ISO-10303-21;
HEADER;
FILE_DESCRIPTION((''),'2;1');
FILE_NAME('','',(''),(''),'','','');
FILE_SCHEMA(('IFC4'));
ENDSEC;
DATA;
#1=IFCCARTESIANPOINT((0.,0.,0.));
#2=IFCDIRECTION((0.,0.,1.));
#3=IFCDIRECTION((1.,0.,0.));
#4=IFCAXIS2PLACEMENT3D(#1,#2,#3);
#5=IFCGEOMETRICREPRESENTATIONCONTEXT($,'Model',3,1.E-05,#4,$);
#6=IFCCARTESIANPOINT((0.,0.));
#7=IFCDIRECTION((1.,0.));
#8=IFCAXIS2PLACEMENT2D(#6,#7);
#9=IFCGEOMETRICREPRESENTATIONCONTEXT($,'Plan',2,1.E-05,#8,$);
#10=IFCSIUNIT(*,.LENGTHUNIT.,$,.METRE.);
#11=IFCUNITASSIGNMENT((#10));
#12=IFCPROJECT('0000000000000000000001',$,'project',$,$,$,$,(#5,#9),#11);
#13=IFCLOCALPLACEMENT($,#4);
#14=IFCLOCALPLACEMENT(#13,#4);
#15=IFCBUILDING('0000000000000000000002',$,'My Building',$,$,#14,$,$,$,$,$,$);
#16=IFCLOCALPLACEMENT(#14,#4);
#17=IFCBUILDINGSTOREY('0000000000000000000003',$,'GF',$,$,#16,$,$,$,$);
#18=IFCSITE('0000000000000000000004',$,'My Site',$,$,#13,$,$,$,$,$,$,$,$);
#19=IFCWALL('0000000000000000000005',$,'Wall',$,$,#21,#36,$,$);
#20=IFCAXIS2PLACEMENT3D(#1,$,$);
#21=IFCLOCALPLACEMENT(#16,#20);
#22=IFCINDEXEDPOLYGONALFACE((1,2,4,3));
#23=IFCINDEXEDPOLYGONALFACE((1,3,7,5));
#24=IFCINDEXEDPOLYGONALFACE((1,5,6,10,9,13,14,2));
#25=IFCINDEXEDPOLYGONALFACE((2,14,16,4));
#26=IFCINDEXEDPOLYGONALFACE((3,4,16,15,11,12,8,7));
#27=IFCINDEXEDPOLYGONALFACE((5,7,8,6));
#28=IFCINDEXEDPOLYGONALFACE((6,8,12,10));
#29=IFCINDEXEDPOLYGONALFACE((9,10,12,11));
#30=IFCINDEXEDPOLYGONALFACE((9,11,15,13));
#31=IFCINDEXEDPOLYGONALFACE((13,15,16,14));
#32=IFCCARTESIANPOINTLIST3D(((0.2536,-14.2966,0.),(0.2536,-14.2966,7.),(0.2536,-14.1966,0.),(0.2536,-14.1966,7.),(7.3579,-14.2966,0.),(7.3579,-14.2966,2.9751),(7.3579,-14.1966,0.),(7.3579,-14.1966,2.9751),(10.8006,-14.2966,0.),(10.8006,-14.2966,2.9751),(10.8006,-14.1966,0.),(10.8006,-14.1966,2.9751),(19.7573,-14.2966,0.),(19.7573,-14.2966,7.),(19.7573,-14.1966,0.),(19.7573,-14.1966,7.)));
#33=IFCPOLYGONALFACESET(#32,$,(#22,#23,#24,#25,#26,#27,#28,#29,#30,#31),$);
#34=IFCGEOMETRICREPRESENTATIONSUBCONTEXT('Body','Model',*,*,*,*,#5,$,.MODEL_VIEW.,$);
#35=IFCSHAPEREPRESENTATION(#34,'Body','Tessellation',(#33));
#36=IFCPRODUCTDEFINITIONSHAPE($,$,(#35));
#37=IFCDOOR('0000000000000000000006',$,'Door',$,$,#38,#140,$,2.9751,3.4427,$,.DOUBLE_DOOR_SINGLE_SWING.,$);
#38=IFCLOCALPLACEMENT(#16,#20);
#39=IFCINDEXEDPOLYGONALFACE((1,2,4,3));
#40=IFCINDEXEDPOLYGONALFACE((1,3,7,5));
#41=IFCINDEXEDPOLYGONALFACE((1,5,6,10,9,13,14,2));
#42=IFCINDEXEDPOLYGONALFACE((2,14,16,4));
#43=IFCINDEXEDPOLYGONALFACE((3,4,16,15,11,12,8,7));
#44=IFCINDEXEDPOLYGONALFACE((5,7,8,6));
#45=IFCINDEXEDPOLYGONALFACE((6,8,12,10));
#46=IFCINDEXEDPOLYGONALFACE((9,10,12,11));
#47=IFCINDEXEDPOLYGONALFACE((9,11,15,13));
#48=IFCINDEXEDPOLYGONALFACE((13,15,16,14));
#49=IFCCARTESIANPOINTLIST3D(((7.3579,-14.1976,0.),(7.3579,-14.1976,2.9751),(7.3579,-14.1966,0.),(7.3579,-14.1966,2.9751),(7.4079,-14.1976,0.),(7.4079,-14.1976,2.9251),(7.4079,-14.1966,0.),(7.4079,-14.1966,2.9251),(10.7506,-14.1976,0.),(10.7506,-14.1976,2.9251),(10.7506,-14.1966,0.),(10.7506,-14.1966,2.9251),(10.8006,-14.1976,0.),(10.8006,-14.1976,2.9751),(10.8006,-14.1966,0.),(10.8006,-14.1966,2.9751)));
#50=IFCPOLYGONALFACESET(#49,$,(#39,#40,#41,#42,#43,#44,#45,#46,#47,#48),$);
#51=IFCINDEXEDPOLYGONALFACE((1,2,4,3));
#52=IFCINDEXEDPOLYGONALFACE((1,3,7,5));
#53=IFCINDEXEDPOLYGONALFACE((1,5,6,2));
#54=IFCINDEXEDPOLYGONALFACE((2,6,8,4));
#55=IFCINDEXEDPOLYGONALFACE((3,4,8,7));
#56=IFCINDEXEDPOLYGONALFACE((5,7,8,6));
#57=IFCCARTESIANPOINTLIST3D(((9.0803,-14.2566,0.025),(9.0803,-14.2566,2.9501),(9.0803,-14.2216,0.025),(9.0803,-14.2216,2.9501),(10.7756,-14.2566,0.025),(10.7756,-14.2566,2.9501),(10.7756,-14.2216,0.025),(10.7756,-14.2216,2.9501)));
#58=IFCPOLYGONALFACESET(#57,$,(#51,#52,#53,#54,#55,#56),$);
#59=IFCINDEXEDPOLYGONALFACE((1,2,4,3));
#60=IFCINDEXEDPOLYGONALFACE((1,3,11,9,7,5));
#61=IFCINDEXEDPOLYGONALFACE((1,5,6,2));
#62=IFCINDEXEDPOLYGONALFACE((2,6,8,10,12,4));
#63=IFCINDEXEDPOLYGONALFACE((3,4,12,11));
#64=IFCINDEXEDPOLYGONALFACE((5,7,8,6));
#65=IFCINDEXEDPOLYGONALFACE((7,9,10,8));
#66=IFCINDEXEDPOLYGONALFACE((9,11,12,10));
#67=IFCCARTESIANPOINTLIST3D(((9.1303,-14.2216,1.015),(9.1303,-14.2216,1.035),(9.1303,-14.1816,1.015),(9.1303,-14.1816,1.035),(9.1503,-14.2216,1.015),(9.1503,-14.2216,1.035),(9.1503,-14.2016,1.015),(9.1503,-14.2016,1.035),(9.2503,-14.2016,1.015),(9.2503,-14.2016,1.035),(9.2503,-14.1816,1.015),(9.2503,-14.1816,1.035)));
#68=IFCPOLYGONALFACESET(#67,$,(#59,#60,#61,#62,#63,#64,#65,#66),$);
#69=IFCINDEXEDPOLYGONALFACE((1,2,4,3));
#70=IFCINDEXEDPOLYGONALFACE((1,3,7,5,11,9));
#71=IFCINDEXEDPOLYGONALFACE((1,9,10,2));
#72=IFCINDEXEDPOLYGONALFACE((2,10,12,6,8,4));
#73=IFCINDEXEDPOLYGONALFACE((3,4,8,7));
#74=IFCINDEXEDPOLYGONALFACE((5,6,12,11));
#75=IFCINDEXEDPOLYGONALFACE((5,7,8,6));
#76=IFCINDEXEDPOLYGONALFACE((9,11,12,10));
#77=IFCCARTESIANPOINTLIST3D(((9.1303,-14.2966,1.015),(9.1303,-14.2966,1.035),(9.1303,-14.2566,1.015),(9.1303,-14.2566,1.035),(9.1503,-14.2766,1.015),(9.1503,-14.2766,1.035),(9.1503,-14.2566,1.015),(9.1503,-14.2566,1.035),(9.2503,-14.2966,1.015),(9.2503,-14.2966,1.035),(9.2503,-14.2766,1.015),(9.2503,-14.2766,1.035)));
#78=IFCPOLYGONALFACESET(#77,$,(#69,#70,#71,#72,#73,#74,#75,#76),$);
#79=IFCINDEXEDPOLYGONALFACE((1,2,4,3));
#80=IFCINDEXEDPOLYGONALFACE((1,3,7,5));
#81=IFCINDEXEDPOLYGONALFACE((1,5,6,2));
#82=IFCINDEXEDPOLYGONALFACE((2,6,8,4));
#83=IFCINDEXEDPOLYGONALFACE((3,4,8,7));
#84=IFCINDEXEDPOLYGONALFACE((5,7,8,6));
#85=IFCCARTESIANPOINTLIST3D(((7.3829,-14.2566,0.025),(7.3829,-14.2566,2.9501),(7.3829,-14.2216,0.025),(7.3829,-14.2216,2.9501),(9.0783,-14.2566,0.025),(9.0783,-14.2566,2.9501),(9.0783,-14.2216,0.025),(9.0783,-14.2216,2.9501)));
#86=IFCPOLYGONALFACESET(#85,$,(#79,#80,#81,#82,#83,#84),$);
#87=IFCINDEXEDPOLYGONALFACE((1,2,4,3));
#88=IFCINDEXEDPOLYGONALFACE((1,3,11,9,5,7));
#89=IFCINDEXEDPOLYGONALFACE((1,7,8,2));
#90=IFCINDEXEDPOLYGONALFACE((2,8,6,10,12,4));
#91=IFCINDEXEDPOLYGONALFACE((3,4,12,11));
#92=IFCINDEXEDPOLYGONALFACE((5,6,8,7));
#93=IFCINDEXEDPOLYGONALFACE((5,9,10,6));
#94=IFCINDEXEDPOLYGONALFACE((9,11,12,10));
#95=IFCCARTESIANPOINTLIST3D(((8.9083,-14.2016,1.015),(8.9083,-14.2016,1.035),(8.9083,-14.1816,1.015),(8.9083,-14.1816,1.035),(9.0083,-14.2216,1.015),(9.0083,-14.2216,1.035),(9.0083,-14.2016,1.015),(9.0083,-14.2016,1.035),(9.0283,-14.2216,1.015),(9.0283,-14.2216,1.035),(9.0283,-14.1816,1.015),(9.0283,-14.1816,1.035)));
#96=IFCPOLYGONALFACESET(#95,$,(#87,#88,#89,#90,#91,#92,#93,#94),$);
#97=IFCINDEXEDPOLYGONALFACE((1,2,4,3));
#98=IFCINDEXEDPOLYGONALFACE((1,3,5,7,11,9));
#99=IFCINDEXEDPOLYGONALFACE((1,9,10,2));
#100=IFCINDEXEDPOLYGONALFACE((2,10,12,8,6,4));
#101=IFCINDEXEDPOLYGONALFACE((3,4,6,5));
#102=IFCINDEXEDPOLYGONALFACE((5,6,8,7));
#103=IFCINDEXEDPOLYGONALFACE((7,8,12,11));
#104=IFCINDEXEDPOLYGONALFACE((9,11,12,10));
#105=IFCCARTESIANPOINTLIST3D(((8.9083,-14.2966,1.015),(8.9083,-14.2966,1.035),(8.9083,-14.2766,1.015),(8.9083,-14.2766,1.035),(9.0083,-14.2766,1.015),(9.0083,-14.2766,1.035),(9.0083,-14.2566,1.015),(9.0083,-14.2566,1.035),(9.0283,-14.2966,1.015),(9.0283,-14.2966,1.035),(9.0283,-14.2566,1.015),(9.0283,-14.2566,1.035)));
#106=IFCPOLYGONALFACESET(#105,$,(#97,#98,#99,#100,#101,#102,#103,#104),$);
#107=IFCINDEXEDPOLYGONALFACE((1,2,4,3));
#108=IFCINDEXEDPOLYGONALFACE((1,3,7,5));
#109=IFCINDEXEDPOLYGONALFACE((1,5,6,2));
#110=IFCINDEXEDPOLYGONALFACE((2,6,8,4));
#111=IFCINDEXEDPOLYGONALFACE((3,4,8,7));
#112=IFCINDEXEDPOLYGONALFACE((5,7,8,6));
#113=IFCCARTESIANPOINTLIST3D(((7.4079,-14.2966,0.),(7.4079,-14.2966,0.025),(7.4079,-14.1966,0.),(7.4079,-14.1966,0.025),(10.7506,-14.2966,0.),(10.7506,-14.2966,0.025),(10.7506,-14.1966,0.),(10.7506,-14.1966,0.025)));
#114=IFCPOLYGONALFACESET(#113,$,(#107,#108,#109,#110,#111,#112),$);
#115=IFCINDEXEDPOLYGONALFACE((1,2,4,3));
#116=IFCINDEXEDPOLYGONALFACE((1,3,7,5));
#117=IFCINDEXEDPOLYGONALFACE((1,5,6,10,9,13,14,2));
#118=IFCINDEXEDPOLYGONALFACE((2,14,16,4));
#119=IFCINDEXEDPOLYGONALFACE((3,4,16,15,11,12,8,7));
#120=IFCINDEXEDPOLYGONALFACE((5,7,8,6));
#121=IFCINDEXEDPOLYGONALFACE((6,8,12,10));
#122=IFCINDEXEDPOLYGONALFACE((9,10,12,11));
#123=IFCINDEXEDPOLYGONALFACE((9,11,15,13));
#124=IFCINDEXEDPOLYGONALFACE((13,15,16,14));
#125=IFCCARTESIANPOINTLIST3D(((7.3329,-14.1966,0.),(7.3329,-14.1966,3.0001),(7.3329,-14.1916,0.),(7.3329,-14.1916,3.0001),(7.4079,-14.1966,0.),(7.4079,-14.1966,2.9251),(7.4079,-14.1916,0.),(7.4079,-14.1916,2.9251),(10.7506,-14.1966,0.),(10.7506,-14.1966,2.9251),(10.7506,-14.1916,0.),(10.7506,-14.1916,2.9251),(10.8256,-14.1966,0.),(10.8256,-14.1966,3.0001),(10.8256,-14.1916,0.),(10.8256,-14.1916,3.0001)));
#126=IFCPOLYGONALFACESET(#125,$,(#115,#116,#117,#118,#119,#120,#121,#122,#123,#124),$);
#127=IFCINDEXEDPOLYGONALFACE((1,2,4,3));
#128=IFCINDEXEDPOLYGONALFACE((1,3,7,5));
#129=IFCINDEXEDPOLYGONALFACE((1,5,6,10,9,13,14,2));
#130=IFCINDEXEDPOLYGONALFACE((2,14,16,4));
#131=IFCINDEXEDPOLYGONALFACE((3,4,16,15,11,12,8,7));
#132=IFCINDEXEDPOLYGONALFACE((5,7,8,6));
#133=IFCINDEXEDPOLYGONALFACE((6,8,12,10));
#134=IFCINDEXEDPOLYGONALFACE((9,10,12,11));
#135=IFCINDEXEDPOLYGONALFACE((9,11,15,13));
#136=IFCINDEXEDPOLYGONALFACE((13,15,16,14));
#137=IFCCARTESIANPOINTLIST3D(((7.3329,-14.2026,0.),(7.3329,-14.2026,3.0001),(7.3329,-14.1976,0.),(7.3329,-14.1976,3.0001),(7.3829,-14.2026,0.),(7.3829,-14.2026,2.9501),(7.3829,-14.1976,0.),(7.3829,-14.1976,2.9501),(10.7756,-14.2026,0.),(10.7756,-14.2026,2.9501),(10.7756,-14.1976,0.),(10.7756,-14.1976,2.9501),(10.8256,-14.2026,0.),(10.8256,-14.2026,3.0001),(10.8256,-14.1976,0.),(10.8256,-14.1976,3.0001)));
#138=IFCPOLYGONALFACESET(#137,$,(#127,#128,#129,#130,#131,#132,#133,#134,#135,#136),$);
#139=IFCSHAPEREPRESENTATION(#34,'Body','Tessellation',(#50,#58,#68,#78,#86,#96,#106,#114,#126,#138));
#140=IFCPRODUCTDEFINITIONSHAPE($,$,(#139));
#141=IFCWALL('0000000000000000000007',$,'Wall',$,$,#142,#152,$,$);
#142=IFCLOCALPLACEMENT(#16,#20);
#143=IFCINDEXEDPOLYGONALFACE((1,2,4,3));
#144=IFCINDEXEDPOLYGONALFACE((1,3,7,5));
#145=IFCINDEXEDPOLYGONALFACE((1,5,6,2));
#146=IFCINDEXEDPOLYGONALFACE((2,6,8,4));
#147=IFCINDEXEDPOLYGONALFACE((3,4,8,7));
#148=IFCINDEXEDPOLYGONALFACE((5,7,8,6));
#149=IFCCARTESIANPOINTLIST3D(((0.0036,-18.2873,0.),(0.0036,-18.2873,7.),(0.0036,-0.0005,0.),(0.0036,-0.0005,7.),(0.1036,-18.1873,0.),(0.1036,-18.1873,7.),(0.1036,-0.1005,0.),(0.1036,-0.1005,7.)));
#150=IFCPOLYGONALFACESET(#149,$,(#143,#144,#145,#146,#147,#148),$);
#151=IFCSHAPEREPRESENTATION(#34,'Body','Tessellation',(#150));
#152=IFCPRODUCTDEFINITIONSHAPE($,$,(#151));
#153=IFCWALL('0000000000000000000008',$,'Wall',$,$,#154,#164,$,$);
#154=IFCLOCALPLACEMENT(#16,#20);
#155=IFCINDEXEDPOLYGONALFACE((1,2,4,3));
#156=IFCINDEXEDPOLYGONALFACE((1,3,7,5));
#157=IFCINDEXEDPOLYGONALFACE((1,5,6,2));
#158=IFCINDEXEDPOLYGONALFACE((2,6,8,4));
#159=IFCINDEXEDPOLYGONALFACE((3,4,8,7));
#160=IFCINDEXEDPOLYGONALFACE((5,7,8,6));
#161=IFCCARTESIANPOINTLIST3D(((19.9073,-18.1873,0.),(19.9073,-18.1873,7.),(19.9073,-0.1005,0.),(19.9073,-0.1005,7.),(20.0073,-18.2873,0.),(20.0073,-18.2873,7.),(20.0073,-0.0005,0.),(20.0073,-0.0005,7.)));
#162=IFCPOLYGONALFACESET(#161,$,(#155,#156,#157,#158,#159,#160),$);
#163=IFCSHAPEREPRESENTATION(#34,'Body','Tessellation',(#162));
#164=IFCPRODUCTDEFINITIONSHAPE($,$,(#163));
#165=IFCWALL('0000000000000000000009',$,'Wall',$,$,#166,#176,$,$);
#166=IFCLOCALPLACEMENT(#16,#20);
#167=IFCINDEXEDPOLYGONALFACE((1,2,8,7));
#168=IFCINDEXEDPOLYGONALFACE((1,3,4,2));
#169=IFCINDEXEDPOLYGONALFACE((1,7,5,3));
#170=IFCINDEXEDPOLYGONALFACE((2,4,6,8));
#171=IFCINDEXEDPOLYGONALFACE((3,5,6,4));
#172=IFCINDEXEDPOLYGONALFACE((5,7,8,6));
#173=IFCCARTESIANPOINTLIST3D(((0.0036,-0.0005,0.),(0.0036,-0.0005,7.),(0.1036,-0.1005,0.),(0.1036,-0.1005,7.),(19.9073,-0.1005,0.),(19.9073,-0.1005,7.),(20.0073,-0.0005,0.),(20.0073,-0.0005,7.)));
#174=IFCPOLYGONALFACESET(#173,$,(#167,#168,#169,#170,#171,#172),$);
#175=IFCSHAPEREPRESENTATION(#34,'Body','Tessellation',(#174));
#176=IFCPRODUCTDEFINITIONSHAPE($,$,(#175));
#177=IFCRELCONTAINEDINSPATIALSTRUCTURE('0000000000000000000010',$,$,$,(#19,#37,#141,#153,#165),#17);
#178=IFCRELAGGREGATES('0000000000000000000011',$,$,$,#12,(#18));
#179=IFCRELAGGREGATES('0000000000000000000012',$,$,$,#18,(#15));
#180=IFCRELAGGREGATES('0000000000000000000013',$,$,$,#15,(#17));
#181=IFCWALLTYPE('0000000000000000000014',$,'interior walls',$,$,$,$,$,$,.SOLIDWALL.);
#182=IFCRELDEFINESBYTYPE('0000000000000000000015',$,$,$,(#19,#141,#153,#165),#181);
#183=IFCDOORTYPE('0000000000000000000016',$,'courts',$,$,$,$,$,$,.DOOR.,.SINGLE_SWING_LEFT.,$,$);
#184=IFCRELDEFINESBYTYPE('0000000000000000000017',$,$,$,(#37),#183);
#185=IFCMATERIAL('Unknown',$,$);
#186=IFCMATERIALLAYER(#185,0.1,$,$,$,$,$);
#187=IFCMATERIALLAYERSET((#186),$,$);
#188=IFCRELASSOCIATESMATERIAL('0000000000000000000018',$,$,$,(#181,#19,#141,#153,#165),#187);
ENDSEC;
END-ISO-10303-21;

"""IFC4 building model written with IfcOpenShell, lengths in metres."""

from ifc_helpers import new_model, entity, si_unit, frame, origin_with_axes, origin_2d_with_axis, place, context, subcontext, project, spatial, line, indexed_curve, outline, extrude, shape, source, transform, mapped, material, layer, layer_set, layer_usage, type_object, type_shapes, element, fill, save


model = new_model("IFC4")

# Units and contexts
model_context = context("Model", 3, precision=1e-05, world=origin_with_axes())
plan_context = context("Plan", 2, precision=1e-05, world=origin_2d_with_axis())
body_context_1 = subcontext(model_context, "Body", "Model", "MODEL_VIEW")
body_context_2 = subcontext(plan_context, "Body", "Plan", "PLAN_VIEW")
ifc_project = project(units=[si_unit("LENGTHUNIT", "METRE")], contexts=[model_context, plan_context])

# Site, building, storey
site_placement = place(None, origin_with_axes())
site = spatial("IfcSite", under=ifc_project, at=site_placement, Name="My Site")
building_placement = place(site_placement, origin_with_axes())
building = spatial("IfcBuilding", under=site, at=building_placement, Name="My Building")
storey_placement = place(building_placement, origin_with_axes())
storey = spatial("IfcBuildingStorey", under=building, at=storey_placement, Name="GF")

# Shared definitions
ifc_material = material(Name="Unknown")

# Wall, opening, door
ifc_layer_1 = layer(ifc_material, 0.1)
ifc_layer_set_1 = layer_set([ifc_layer_1])
ifc_layer_usage_1 = layer_usage(ifc_layer_set_1, "AXIS2", "POSITIVE", 0.0)
wall_type = type_object("IfcWallType", Name="interior walls", PredefinedType="SOLIDWALL", material=ifc_layer_set_1)
wall_1_placement = place(storey_placement, frame((0.2536, -14.2966, 0.0), z_axis=(0.0, 0.0, 1.0), x_axis=(1.0, 0.0, 0.0)))
wall_1 = element("IfcWall", 1, at=wall_1_placement, inside=storey, type_object=wall_type, material=ifc_layer_usage_1, Name="Wall", context=body_context_1, shape_type="SweptSolid", body=[
    extrude(outline(indexed_curve([(0.0, 0.0), (0.0, 0.1), (19.5037, 0.1), (19.5037, 0.0)], segments=[line(1, 2, 3, 4, 1)])), origin_with_axes(), (0.0, 0.0, 1.0), 7.0),
])
shared_shape_1 = source(origin_with_axes(), body_context_1, "Body", "SweptSolid", [
    extrude(outline(indexed_curve([(0.0, 0.0), (3.4427, 0.0), (3.4427, 2.9751), (0.0, 2.9751)], segments=[line(1, 2, 3, 4, 1)])), frame((0.0, -0.6, 0.0), z_axis=(0.0, -1.0, 0.0), x_axis=(1.0, 0.0, 0.0)), (0.0, 0.0, -1.0), 1.2),
])
opening_1_placement = place(wall_1_placement, frame((10.547, 0.1, 0.0), z_axis=(0.0, 0.0, 1.0), x_axis=(-1.0, 0.0, 0.0)))
opening_1 = element("IfcOpeningElement", 2, at=opening_1_placement, cuts=wall_1, PredefinedType="OPENING", context=body_context_1, shape_type="MappedRepresentation", body=[
    mapped(shared_shape_1, transform((0.0, 0.0, 0.0), x_axis=(1.0, 0.0, 0.0), y_axis=(0.0, 1.0, 0.0), z_axis=(0.0, 0.0, 1.0), scale=1.0)),
])
door_type_1 = type_object("IfcDoorType", Name="courts", OperationType="SINGLE_SWING_LEFT", PredefinedType="DOOR")
shared_shape_2 = source(origin_with_axes(), body_context_1, "Body", "SweptSolid", [
    extrude(outline(indexed_curve([(0.0, 0.0), (0.0, 2.9751), (3.4427, 2.9751), (3.4427, 0.0), (3.3927, 0.0), (3.3927, 2.9251), (0.05, 2.9251), (0.05, 0.0)], segments=[line(1, 2, 3, 4, 5, 6, 7, 8, 1)])), frame((0.0, 0.0, 0.0), z_axis=(0.0, -1.0, 0.0), x_axis=(1.0, 0.0, 0.0)), (0.0, 0.0, -1.0), 0.001),
    extrude(outline(indexed_curve([(0.0, 0.0), (1.6954, 0.0), (1.6954, 0.035), (0.0, 0.035)], segments=[line(1, 2, 3, 4, 1)])), frame((0.025, 0.025, 0.025), z_axis=(0.0, 0.0, 1.0), x_axis=(1.0, 0.0, 0.0)), (0.0, 0.0, 1.0), 2.9251),
    extrude(outline(indexed_curve([(0.0, 0.0), (0.0, -0.04), (-0.12, -0.04), (-0.12, -0.02), (-0.02, -0.02), (-0.02, 0.0)], segments=[line(1, 2, 3, 4, 5, 6, 1)])), frame((1.6704, 0.025, 1.015), z_axis=(0.0, 0.0, 1.0), x_axis=(1.0, 0.0, 0.0)), (0.0, 0.0, 1.0), 0.02),
    extrude(outline(indexed_curve([(0.0, 0.0), (0.0, 0.04), (-0.12, 0.04), (-0.12, 0.02), (-0.02, 0.02), (-0.02, 0.0)], segments=[line(1, 2, 3, 4, 5, 6, 1)])), frame((1.6704, 0.06, 1.015), z_axis=(0.0, 0.0, 1.0), x_axis=(1.0, 0.0, 0.0)), (0.0, 0.0, 1.0), 0.02),
    extrude(outline(indexed_curve([(0.0, 0.0), (-1.6954, 0.0), (-1.6954, 0.035), (0.0, 0.035)], segments=[line(1, 2, 3, 4, 1)])), frame((3.4177, 0.025, 0.025), z_axis=(0.0, 0.0, 1.0), x_axis=(1.0, 0.0, 0.0)), (0.0, 0.0, 1.0), 2.9251),
    extrude(outline(indexed_curve([(0.0, 0.0), (0.0, -0.04), (0.12, -0.04), (0.12, -0.02), (0.02, -0.02), (0.02, 0.0)], segments=[line(1, 2, 3, 4, 5, 6, 1)])), frame((1.7724, 0.025, 1.015), z_axis=(0.0, 0.0, 1.0), x_axis=(1.0, 0.0, 0.0)), (0.0, 0.0, 1.0), 0.02),
    extrude(outline(indexed_curve([(0.0, 0.0), (0.0, 0.04), (0.12, 0.04), (0.12, 0.02), (0.02, 0.02), (0.02, 0.0)], segments=[line(1, 2, 3, 4, 5, 6, 1)])), frame((1.7724, 0.06, 1.015), z_axis=(0.0, 0.0, 1.0), x_axis=(1.0, 0.0, 0.0)), (0.0, 0.0, 1.0), 0.02),
    extrude(outline(indexed_curve([(0.0, 0.0), (3.3427, 0.0), (3.3427, 0.1), (0.0, 0.1)], segments=[line(1, 2, 3, 4, 1)])), frame((0.05, 0.0, 0.0), z_axis=(0.0, 0.0, 1.0), x_axis=(1.0, 0.0, 0.0)), (0.0, 0.0, 1.0), 0.025),
    extrude(outline(indexed_curve([(0.0, 0.0), (0.0, 3.0001), (3.4927, 3.0001), (3.4927, 0.0), (3.4177, 0.0), (3.4177, 2.9251), (0.075, 2.9251), (0.075, 0.0)], segments=[line(1, 2, 3, 4, 5, 6, 7, 8, 1)])), frame((-0.025, -0.005, 0.0), z_axis=(0.0, -1.0, 0.0), x_axis=(1.0, 0.0, 0.0)), (0.0, 0.0, -1.0), 0.005),
    extrude(outline(indexed_curve([(0.0, 0.0), (0.0, 3.0001), (3.4927, 3.0001), (3.4927, 0.0), (3.4427, 0.0), (3.4427, 2.9501), (0.05, 2.9501), (0.05, 0.0)], segments=[line(1, 2, 3, 4, 5, 6, 7, 8, 1)])), frame((-0.025, 0.001, 0.0), z_axis=(0.0, -1.0, 0.0), x_axis=(1.0, 0.0, 0.0)), (0.0, 0.0, -1.0), 0.005),
])
shared_shape_3 = source(origin_with_axes(), body_context_2, "Body", "Curve2D", [
    entity("IfcIndexedPolyCurve", entity("IfcCartesianPointList2D", [[0.0, 0.0], [0.05, 0.0], [0.05, 0.001], [0.0, 0.001]]), [entity("IfcLineIndex", [1, 2, 3, 4, 1])]),
    entity("IfcIndexedPolyCurve", entity("IfcCartesianPointList2D", [[3.4427, 0.0], [3.3927, 0.0], [3.3927, 0.001], [3.4427, 0.001]]), [entity("IfcLineIndex", [1, 2, 3, 4, 1])]),
    entity("IfcTrimmedCurve", entity("IfcEllipse", entity("IfcAxis2Placement2D", entity("IfcCartesianPoint", [0.06, 0.001]), entity("IfcDirection", [1.0, 0.0])), 1.6614, 1.6964), [entity("IfcCartesianPoint", [1.7214, 0.001])], [entity("IfcCartesianPoint", [0.06, 1.6974])], True, "CARTESIAN"),
    entity("IfcIndexedPolyCurve", entity("IfcCartesianPointList2D", [[0.025, 0.001], [0.06, 0.001], [0.06, 1.6974], [0.025, 1.6974]]), [entity("IfcLineIndex", [1, 2, 3, 4, 1])]),
    entity("IfcTrimmedCurve", entity("IfcEllipse", entity("IfcAxis2Placement2D", entity("IfcCartesianPoint", [3.3827, 0.001]), entity("IfcDirection", [1.0, 0.0])), 1.6614, 1.6964), [entity("IfcCartesianPoint", [3.3827, 1.6974])], [entity("IfcCartesianPoint", [1.7214, 0.001])], True, "CARTESIAN"),
    entity("IfcIndexedPolyCurve", entity("IfcCartesianPointList2D", [[3.4177, 0.001], [3.3827, 0.001], [3.3827, 1.6974], [3.4177, 1.6974]]), [entity("IfcLineIndex", [1, 2, 3, 4, 1])]),
])
type_shapes(door_type_1, [shared_shape_2, shared_shape_3])
door_1_placement = place(opening_1_placement, origin_with_axes())
door_1 = element("IfcDoor", 3, at=door_1_placement, inside=storey, type_object=door_type_1, Name="Door", OperationType="DOUBLE_DOOR_SINGLE_SWING", OverallHeight=2.9751, OverallWidth=3.4427, shapes=[
    shape(body_context_1, "Body", "MappedRepresentation", [mapped(shared_shape_2, transform((0.0, 0.0, 0.0), x_axis=(1.0, 0.0, 0.0), y_axis=(0.0, 1.0, 0.0), z_axis=(0.0, 0.0, 1.0), scale=1.0))]),
    shape(body_context_2, "Body", "MappedRepresentation", [mapped(shared_shape_3, transform((0.0, 0.0, 0.0), x_axis=(1.0, 0.0, 0.0), y_axis=(0.0, 1.0, 0.0), z_axis=(0.0, 0.0, 1.0), scale=1.0))]),
])
fill(opening_1, door_1)

# Wall
ifc_layer_usage_2 = layer_usage(ifc_layer_set_1, "AXIS2", "POSITIVE", 0.0)
wall_2_placement = place(storey_placement, frame((0.0036, -0.0005, 0.0), z_axis=(0.0, 0.0, 1.0), x_axis=(0.0, -1.0, 0.0)))
element("IfcWall", 4, at=wall_2_placement, inside=storey, type_object=wall_type, material=ifc_layer_usage_2, Name="Wall", context=body_context_1, shape_type="SweptSolid", body=[
    extrude(outline(indexed_curve([(0.0, 0.0), (0.1, 0.1), (18.1869, 0.1), (18.2869, 0.0)], segments=[line(1, 2, 3, 4, 1)])), origin_with_axes(), (0.0, 0.0, 1.0), 7.0),
])

# Walls
ifc_layer_usage_3 = layer_usage(ifc_layer_set_1, "AXIS2", "POSITIVE", 0.0)
wall_3_placement = place(storey_placement, frame((20.0073, -18.2873, 0.0), z_axis=(0.0, 0.0, 1.0), x_axis=(0.0, 1.0, 0.0)))
element("IfcWall", 5, at=wall_3_placement, inside=storey, type_object=wall_type, material=ifc_layer_usage_3, Name="Wall", context=body_context_1, shape_type="SweptSolid", body=[
    extrude(outline(indexed_curve([(0.0, 0.0), (0.1, 0.1), (18.1869, 0.1), (18.2869, 0.0)], segments=[line(1, 2, 3, 4, 1)])), origin_with_axes(), (0.0, 0.0, 1.0), 7.0),
])
ifc_layer_usage_4 = layer_usage(ifc_layer_set_1, "AXIS2", "POSITIVE", 0.0)
wall_4_placement = place(storey_placement, frame((20.0073, -0.0005, 0.0), z_axis=(0.0, 0.0, 1.0), x_axis=(-1.0, 0.0, 0.0)))
element("IfcWall", 6, at=wall_4_placement, inside=storey, type_object=wall_type, material=ifc_layer_usage_4, Name="Wall", context=body_context_1, shape_type="SweptSolid", body=[
    extrude(outline(indexed_curve([(0.0, 0.0), (0.1, 0.1), (19.9037, 0.1), (20.0037, 0.0)], segments=[line(1, 2, 3, 4, 1)])), origin_with_axes(), (0.0, 0.0, 1.0), 7.0),
])

save(model, "model.ifc")
